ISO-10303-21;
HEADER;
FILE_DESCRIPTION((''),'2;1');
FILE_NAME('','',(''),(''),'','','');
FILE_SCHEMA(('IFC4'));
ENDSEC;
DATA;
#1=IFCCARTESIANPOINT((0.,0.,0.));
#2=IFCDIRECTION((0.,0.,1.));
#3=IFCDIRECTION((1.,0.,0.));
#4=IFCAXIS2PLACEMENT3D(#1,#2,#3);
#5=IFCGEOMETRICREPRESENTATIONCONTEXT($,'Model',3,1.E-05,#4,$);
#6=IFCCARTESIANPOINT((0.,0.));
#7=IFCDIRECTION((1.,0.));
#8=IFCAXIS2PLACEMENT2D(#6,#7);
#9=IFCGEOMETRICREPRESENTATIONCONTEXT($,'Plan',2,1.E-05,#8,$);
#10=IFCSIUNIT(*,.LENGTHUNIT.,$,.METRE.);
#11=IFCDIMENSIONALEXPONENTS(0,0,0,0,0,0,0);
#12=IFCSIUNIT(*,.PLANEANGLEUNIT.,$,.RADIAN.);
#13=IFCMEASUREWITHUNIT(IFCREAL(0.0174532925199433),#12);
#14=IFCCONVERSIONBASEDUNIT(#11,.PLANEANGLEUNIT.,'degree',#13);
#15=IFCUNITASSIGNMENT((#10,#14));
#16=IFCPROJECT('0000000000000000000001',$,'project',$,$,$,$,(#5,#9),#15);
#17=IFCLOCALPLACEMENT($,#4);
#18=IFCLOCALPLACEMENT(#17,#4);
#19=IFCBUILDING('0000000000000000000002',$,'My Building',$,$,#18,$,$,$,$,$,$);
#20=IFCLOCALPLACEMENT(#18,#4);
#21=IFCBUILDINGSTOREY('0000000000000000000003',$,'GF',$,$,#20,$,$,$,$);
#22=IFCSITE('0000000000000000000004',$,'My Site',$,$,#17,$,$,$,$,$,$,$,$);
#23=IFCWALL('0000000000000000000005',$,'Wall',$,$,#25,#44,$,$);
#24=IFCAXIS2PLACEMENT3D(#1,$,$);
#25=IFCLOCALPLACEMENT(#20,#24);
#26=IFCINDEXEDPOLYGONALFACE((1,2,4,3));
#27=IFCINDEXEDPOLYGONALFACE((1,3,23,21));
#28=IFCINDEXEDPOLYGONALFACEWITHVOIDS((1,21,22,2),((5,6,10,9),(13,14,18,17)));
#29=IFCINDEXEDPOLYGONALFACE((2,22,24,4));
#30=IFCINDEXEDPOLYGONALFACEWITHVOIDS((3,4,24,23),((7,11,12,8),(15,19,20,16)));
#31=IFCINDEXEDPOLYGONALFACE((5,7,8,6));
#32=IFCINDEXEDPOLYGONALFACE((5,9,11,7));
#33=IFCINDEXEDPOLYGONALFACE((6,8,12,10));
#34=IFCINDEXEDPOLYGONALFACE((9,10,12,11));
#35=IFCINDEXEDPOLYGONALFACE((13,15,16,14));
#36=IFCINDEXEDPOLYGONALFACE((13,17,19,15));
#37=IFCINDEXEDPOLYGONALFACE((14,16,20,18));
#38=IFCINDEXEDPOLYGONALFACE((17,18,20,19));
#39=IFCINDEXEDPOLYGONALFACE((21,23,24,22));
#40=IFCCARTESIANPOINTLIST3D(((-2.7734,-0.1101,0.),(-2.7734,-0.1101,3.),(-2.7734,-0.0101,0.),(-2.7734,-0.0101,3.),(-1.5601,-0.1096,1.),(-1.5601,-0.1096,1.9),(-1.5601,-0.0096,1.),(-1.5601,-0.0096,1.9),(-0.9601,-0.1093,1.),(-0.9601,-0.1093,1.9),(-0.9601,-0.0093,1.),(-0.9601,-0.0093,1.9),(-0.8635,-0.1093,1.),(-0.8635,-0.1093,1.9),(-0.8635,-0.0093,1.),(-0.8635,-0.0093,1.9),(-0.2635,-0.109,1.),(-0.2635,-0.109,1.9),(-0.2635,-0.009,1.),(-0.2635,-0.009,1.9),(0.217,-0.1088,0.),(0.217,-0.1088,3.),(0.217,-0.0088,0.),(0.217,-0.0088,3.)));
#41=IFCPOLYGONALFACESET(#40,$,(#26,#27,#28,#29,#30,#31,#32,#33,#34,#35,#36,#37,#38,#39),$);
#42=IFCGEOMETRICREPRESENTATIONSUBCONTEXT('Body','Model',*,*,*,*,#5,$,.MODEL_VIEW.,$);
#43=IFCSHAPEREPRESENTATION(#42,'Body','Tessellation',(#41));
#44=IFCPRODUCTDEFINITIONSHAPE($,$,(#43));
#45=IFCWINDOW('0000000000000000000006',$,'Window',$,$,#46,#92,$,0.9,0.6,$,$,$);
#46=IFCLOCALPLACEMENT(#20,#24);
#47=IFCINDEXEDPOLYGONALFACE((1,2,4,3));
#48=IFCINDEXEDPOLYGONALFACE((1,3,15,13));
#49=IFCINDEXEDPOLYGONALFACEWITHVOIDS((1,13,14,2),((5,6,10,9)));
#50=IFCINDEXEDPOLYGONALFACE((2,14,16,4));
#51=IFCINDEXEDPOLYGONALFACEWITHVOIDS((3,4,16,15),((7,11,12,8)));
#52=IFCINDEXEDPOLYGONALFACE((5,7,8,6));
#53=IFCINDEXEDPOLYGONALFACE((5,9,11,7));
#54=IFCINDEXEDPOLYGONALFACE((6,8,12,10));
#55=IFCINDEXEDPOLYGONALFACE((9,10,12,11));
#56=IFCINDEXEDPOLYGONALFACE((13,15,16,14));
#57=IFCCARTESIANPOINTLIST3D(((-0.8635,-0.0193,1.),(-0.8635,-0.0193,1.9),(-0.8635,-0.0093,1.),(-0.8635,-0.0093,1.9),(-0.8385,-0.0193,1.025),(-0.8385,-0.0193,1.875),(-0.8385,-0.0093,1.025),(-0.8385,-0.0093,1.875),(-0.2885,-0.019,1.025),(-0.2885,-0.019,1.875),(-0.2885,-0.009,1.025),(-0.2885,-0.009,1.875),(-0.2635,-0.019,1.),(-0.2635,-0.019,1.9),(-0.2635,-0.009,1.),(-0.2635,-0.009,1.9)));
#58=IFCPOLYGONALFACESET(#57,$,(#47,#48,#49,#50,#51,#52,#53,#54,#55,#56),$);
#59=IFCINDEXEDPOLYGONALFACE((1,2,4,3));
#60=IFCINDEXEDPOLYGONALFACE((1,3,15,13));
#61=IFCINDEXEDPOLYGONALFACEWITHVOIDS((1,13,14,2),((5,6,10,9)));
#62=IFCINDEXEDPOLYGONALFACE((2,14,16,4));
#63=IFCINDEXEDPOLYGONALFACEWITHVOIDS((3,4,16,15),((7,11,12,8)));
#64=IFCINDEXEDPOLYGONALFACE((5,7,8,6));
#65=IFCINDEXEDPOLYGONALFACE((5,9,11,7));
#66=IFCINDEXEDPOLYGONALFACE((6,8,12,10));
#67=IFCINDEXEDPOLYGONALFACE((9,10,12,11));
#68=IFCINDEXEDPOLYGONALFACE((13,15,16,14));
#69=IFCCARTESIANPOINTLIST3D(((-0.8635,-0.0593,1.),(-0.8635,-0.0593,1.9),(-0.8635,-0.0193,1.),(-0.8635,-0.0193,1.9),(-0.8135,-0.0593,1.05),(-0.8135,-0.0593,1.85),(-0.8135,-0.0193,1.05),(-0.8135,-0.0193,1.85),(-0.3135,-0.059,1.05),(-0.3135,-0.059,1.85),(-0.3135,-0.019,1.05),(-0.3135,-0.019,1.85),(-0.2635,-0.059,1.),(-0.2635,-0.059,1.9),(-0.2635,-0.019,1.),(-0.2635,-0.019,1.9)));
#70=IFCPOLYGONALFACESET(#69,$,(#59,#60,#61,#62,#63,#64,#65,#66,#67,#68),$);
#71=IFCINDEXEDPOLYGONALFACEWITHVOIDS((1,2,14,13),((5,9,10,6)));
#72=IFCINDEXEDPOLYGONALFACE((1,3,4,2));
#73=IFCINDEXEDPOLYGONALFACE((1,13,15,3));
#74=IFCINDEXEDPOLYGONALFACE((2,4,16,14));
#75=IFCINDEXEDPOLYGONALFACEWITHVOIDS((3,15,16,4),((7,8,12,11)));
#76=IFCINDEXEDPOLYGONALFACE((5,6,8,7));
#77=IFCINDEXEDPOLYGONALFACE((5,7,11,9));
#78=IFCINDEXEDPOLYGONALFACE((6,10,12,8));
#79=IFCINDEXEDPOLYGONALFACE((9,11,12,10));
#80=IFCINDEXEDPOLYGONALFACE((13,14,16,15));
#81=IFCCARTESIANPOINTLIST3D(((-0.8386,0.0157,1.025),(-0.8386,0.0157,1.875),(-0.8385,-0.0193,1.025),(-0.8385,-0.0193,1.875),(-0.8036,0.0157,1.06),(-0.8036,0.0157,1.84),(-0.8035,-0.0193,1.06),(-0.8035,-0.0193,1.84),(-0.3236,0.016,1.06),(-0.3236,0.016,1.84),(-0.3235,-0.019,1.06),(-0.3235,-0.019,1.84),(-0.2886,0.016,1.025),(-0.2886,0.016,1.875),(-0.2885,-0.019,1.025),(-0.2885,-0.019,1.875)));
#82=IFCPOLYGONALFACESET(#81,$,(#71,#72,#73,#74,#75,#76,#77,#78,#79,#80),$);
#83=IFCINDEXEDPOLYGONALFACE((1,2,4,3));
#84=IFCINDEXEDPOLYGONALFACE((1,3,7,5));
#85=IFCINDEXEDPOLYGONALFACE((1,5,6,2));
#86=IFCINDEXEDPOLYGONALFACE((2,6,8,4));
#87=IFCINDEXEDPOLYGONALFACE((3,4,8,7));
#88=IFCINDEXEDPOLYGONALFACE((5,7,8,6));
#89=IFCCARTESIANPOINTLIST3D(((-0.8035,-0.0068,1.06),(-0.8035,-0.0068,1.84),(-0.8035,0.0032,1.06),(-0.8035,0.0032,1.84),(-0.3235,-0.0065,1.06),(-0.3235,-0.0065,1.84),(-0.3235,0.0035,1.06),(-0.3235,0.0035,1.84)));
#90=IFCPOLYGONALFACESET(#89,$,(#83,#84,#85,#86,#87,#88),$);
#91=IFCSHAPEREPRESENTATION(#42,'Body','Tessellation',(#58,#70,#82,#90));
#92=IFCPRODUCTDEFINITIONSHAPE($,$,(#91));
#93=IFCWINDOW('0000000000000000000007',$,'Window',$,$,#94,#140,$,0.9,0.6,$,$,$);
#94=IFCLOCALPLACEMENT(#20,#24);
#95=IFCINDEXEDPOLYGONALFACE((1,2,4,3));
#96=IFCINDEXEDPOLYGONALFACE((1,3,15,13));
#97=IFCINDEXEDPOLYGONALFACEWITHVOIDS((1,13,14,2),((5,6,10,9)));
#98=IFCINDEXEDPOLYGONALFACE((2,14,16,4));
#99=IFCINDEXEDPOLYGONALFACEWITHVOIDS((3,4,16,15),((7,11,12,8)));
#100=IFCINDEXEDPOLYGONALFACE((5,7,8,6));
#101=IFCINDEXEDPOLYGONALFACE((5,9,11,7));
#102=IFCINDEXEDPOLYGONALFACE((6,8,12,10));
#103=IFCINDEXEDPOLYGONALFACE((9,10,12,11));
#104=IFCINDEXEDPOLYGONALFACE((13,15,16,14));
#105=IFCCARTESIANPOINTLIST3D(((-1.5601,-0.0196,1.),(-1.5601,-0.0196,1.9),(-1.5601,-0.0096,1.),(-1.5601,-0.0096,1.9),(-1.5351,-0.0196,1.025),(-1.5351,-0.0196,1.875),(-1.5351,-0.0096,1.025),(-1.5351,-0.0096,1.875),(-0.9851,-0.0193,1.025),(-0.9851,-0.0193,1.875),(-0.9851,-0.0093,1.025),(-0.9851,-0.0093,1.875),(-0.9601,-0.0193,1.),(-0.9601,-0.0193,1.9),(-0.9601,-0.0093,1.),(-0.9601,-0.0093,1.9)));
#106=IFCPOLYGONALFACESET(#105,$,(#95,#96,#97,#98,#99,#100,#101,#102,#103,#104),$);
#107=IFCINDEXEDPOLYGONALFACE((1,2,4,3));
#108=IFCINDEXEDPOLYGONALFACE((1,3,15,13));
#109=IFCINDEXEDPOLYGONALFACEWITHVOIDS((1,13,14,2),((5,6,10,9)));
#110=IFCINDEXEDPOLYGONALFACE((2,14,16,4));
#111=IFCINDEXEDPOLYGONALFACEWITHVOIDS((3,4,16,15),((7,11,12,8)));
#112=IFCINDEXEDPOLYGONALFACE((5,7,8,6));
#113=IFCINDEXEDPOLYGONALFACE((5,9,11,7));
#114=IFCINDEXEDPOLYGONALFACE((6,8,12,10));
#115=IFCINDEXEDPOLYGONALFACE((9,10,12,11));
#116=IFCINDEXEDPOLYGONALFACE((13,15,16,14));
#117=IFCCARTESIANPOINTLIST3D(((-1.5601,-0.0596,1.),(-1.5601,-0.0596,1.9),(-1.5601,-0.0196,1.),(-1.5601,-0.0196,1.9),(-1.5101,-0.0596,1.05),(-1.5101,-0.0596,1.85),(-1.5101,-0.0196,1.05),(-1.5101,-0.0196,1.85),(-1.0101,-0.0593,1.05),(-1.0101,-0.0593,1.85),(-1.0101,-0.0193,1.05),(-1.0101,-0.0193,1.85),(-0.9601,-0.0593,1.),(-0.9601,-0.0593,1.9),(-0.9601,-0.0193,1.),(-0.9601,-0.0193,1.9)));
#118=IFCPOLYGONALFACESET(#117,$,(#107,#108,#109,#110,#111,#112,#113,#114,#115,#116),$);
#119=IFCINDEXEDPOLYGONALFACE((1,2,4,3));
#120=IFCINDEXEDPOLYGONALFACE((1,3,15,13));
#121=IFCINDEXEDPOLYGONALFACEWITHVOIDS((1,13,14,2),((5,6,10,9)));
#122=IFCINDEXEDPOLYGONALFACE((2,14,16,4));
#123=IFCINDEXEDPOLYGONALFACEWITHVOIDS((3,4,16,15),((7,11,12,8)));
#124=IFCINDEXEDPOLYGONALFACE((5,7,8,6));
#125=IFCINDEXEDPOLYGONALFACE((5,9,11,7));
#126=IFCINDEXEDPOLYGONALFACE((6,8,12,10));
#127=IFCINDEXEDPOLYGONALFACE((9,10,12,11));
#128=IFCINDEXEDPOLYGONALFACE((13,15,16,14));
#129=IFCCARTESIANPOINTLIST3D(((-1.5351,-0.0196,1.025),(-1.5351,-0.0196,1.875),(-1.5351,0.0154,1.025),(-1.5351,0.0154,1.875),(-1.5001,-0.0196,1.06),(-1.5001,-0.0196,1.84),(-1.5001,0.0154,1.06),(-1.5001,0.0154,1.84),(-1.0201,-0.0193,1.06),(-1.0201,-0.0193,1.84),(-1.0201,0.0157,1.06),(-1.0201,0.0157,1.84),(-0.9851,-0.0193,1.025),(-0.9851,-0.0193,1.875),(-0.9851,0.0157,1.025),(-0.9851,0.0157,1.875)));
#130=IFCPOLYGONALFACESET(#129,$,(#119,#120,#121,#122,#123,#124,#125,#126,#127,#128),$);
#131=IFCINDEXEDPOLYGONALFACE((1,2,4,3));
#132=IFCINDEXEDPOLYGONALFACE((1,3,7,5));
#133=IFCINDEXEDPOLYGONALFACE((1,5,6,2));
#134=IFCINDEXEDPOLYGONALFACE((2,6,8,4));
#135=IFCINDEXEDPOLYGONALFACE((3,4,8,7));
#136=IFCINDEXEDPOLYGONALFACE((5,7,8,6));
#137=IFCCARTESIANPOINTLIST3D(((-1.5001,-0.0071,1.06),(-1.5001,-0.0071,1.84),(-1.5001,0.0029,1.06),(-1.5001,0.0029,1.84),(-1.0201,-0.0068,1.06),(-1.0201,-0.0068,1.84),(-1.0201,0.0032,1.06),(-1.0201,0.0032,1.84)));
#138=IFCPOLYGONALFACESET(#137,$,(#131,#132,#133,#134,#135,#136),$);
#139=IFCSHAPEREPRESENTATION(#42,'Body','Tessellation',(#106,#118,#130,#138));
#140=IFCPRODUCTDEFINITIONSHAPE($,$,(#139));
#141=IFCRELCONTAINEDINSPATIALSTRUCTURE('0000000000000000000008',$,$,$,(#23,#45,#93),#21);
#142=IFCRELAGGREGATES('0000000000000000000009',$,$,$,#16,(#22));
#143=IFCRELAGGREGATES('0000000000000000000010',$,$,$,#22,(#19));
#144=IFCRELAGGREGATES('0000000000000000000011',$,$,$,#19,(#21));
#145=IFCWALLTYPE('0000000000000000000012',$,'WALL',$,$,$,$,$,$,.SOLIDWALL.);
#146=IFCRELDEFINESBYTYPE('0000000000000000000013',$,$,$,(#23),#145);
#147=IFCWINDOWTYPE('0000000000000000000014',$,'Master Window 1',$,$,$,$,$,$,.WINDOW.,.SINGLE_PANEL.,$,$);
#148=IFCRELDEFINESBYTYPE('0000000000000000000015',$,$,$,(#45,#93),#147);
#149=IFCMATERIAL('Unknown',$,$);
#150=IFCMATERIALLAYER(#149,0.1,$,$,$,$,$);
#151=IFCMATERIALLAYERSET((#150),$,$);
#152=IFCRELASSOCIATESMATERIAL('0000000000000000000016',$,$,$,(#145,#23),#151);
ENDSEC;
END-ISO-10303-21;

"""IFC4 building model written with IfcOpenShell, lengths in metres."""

from ifc_helpers import new_model, entity, si_unit, converted_unit, frame, origin_with_axes, origin_2d_with_axis, place, context, subcontext, project, spatial, line, indexed_curve, outline, extrude, shape, source, transform, mapped, material, layer, layer_set, layer_usage, type_object, type_shapes, element, fill, save


model = new_model("IFC4")

# Units and contexts
model_context = context("Model", 3, precision=1e-05, world=origin_with_axes())
plan_context = context("Plan", 2, precision=1e-05, world=origin_2d_with_axis())
body_context_1 = subcontext(model_context, "Body", "Model", "MODEL_VIEW")
body_context_2 = subcontext(plan_context, "Body", "Plan", "PLAN_VIEW")
ifc_project = project(units=[si_unit("LENGTHUNIT", "METRE"), converted_unit("PLANEANGLEUNIT", "degree", entity("IfcReal", 0.0174532925199433), si_unit("PLANEANGLEUNIT", "RADIAN"), dimensions=[0, 0, 0, 0, 0, 0, 0])], contexts=[model_context, plan_context])

# Site, building, storey
site_placement = place(None, origin_with_axes())
site = spatial("IfcSite", under=ifc_project, at=site_placement, Name="My Site")
building_placement = place(site_placement, origin_with_axes())
building = spatial("IfcBuilding", under=site, at=building_placement, Name="My Building")
storey_placement = place(building_placement, origin_with_axes())
storey = spatial("IfcBuildingStorey", under=building, at=storey_placement, Name="GF")

# Shared definitions
ifc_material = material(Name="Unknown")

# Shared definitions
ifc_layer_1 = layer(ifc_material, 0.1)
ifc_layer_set_1 = layer_set([ifc_layer_1])
wall_type_1 = type_object("IfcWallType", Name="WALL", PredefinedType="SOLIDWALL", material=ifc_layer_set_1)

# Wall, openings, windows
ifc_layer_usage_1 = layer_usage(ifc_layer_set_1, "AXIS2", "POSITIVE", 0.0)
wall_1_placement = place(storey_placement, frame((-2.7734, -0.1101, 0.0), z_axis=(0.0, 0.0, 1.0), x_axis=(1.0, 0.000433, 0.0)))
wall_1 = element("IfcWall", 1, at=wall_1_placement, inside=storey, type_object=wall_type_1, material=ifc_layer_usage_1, Name="Wall", context=body_context_1, shape_type="SweptSolid", body=[
    extrude(outline(indexed_curve([(0.0, 0.0), (0.0, 0.1), (2.9904, 0.1), (2.9904, 0.0)], segments=[line(1, 2, 3, 4, 1)])), origin_with_axes(), (0.0, 0.0, 1.0), 3.0),
])
shared_shape_1 = source(origin_with_axes(), body_context_1, "Body", "SweptSolid", [
    extrude(outline(indexed_curve([(0.0, 0.0), (0.6, 0.0), (0.6, 0.9), (0.0, 0.9)], segments=[line(1, 2, 3, 4, 1)])), frame((0.0, -0.6, 0.0), z_axis=(0.0, -1.0, 0.0), x_axis=(1.0, 0.0, 0.0)), (0.0, 0.0, -1.0), 1.2),
])
opening_1_placement = place(wall_1_placement, frame((1.9099, 0.0, 1.0), z_axis=(0.0, 0.0, 1.0), x_axis=(1.0, 0.0, 0.0)))
opening_1 = element("IfcOpeningElement", 2, at=opening_1_placement, cuts=wall_1, PredefinedType="OPENING", context=body_context_1, shape_type="MappedRepresentation", body=[
    mapped(shared_shape_1, transform((0.0, 0.0, 0.0), x_axis=(1.0, 0.0, 0.0), y_axis=(0.0, 1.0, 0.0), z_axis=(0.0, 0.0, 1.0), scale=1.0)),
])
opening_2_placement = place(wall_1_placement, frame((1.2133, 0.0, 1.0), z_axis=(0.0, 0.0, 1.0), x_axis=(1.0, 0.0, 0.0)))
opening_2 = element("IfcOpeningElement", 3, at=opening_2_placement, cuts=wall_1, PredefinedType="OPENING", context=body_context_1, shape_type="MappedRepresentation", body=[
    mapped(shared_shape_1, transform((0.0, 0.0, 0.0), x_axis=(1.0, 0.0, 0.0), y_axis=(0.0, 1.0, 0.0), z_axis=(0.0, 0.0, 1.0), scale=1.0)),
])
window_type_1 = type_object("IfcWindowType", Name="Master Window 1", PartitioningType="SINGLE_PANEL", PredefinedType="WINDOW")
shared_shape_2 = source(origin_with_axes(), body_context_1, "Body", "SweptSolid", [
    extrude(outline(indexed_curve([(0.0, 0.0), (0.6, 0.0), (0.6, 0.9), (0.0, 0.9)], segments=[line(1, 2, 3, 4, 1)]), holes=[indexed_curve([(0.025, 0.025), (0.575, 0.025), (0.575, 0.875), (0.025, 0.875)], segments=[line(1, 2, 3, 4, 1)])]), frame((0.0, 0.09, 0.0), z_axis=(0.0, -1.0, 0.0), x_axis=(1.0, 0.0, 0.0)), (0.0, 0.0, -1.0), 0.01),
    extrude(outline(indexed_curve([(0.0, 0.0), (0.6, 0.0), (0.6, 0.9), (0.0, 0.9)], segments=[line(1, 2, 3, 4, 1)]), holes=[indexed_curve([(0.05, 0.05), (0.55, 0.05), (0.55, 0.85), (0.05, 0.85)], segments=[line(1, 2, 3, 4, 1)])]), frame((0.0, 0.05, 0.0), z_axis=(0.0, -1.0, 0.0), x_axis=(1.0, 0.0, 0.0)), (0.0, 0.0, -1.0), 0.04),
    extrude(outline(indexed_curve([(0.0, 0.0), (0.55, 0.0), (0.55, 0.85), (0.0, 0.85)], segments=[line(1, 2, 3, 4, 1)]), holes=[indexed_curve([(0.035, 0.035), (0.515, 0.035), (0.515, 0.815), (0.035, 0.815)], segments=[line(1, 2, 3, 4, 1)])]), frame((0.025, 0.09, 0.025), z_axis=(0.0, -1.0, 0.0), x_axis=(1.0, 0.0, 0.0)), (0.0, 0.0, -1.0), 0.035),
    extrude(outline(indexed_curve([(0.035, 0.035), (0.515, 0.035), (0.515, 0.815), (0.035, 0.815)], segments=[line(1, 2, 3, 4, 1)])), frame((0.025, 0.1025, 0.025), z_axis=(0.0, -1.0, 0.0), x_axis=(1.0, 0.0, 0.0)), (0.0, 0.0, -1.0), 0.01),
])
shared_shape_3 = source(origin_with_axes(), body_context_2, "Body", "Curve2D", [
    entity("IfcIndexedPolyCurve", entity("IfcCartesianPointList2D", [[0.05, 0.05], [0.55, 0.05]])),
    entity("IfcIndexedPolyCurve", entity("IfcCartesianPointList2D", [[0.0, 0.1], [0.025, 0.1], [0.025, 0.09], [0.05, 0.09], [0.05, 0.05], [0.0, 0.05]]), [entity("IfcLineIndex", [1, 2, 3, 4, 5, 6, 1])]),
    entity("IfcIndexedPolyCurve", entity("IfcCartesianPointList2D", [[0.6, 0.1], [0.575, 0.1], [0.575, 0.09], [0.55, 0.09], [0.55, 0.05], [0.6, 0.05]]), [entity("IfcLineIndex", [1, 2, 3, 4, 5, 6, 1])]),
    entity("IfcIndexedPolyCurve", entity("IfcCartesianPointList2D", [[0.025, 0.09], [0.06, 0.09], [0.06, 0.125], [0.025, 0.125]]), [entity("IfcLineIndex", [1, 2, 3, 4, 1])]),
    entity("IfcIndexedPolyCurve", entity("IfcCartesianPointList2D", [[0.575, 0.09], [0.54, 0.09], [0.54, 0.125], [0.575, 0.125]]), [entity("IfcLineIndex", [1, 2, 3, 4, 1])]),
    entity("IfcIndexedPolyCurve", entity("IfcCartesianPointList2D", [[0.06, 0.09], [0.54, 0.09]])),
    entity("IfcIndexedPolyCurve", entity("IfcCartesianPointList2D", [[0.06, 0.125], [0.54, 0.125]])),
    entity("IfcIndexedPolyCurve", entity("IfcCartesianPointList2D", [[0.06, 0.1075], [0.54, 0.1075]])),
])
type_shapes(window_type_1, [shared_shape_2, shared_shape_3])
window_1_placement = place(opening_1_placement, frame((0.0, 0.0, 0.0), z_axis=(0.0, 0.0, 1.0), x_axis=(1.0, 0.0, 0.0)))
window_1 = element("IfcWindow", 4, at=window_1_placement, inside=storey, type_object=window_type_1, Name="Window", OverallHeight=0.9, OverallWidth=0.6, shapes=[
    shape(body_context_1, "Body", "MappedRepresentation", [mapped(shared_shape_2, transform((0.0, 0.0, 0.0), x_axis=(1.0, 0.0, 0.0), y_axis=(0.0, 1.0, 0.0), z_axis=(0.0, 0.0, 1.0), scale=1.0))]),
    shape(body_context_2, "Body", "MappedRepresentation", [mapped(shared_shape_3, transform((0.0, 0.0, 0.0), x_axis=(1.0, 0.0, 0.0), y_axis=(0.0, 1.0, 0.0), z_axis=(0.0, 0.0, 1.0), scale=1.0))]),
])
fill(opening_1, window_1)
window_2_placement = place(opening_2_placement, frame((0.0, 0.0, 0.0), z_axis=(0.0, 0.0, 1.0), x_axis=(1.0, 0.0, 0.0)))
window_2 = element("IfcWindow", 5, at=window_2_placement, inside=storey, type_object=window_type_1, Name="Window", OverallHeight=0.9, OverallWidth=0.6, shapes=[
    shape(body_context_1, "Body", "MappedRepresentation", [mapped(shared_shape_2, transform((0.0, 0.0, 0.0), x_axis=(1.0, 0.0, 0.0), y_axis=(0.0, 1.0, 0.0), z_axis=(0.0, 0.0, 1.0), scale=1.0))]),
    shape(body_context_2, "Body", "MappedRepresentation", [mapped(shared_shape_3, transform((0.0, 0.0, 0.0), x_axis=(1.0, 0.0, 0.0), y_axis=(0.0, 1.0, 0.0), z_axis=(0.0, 0.0, 1.0), scale=1.0))]),
])
fill(opening_2, window_2)

save(model, "model.ifc")
